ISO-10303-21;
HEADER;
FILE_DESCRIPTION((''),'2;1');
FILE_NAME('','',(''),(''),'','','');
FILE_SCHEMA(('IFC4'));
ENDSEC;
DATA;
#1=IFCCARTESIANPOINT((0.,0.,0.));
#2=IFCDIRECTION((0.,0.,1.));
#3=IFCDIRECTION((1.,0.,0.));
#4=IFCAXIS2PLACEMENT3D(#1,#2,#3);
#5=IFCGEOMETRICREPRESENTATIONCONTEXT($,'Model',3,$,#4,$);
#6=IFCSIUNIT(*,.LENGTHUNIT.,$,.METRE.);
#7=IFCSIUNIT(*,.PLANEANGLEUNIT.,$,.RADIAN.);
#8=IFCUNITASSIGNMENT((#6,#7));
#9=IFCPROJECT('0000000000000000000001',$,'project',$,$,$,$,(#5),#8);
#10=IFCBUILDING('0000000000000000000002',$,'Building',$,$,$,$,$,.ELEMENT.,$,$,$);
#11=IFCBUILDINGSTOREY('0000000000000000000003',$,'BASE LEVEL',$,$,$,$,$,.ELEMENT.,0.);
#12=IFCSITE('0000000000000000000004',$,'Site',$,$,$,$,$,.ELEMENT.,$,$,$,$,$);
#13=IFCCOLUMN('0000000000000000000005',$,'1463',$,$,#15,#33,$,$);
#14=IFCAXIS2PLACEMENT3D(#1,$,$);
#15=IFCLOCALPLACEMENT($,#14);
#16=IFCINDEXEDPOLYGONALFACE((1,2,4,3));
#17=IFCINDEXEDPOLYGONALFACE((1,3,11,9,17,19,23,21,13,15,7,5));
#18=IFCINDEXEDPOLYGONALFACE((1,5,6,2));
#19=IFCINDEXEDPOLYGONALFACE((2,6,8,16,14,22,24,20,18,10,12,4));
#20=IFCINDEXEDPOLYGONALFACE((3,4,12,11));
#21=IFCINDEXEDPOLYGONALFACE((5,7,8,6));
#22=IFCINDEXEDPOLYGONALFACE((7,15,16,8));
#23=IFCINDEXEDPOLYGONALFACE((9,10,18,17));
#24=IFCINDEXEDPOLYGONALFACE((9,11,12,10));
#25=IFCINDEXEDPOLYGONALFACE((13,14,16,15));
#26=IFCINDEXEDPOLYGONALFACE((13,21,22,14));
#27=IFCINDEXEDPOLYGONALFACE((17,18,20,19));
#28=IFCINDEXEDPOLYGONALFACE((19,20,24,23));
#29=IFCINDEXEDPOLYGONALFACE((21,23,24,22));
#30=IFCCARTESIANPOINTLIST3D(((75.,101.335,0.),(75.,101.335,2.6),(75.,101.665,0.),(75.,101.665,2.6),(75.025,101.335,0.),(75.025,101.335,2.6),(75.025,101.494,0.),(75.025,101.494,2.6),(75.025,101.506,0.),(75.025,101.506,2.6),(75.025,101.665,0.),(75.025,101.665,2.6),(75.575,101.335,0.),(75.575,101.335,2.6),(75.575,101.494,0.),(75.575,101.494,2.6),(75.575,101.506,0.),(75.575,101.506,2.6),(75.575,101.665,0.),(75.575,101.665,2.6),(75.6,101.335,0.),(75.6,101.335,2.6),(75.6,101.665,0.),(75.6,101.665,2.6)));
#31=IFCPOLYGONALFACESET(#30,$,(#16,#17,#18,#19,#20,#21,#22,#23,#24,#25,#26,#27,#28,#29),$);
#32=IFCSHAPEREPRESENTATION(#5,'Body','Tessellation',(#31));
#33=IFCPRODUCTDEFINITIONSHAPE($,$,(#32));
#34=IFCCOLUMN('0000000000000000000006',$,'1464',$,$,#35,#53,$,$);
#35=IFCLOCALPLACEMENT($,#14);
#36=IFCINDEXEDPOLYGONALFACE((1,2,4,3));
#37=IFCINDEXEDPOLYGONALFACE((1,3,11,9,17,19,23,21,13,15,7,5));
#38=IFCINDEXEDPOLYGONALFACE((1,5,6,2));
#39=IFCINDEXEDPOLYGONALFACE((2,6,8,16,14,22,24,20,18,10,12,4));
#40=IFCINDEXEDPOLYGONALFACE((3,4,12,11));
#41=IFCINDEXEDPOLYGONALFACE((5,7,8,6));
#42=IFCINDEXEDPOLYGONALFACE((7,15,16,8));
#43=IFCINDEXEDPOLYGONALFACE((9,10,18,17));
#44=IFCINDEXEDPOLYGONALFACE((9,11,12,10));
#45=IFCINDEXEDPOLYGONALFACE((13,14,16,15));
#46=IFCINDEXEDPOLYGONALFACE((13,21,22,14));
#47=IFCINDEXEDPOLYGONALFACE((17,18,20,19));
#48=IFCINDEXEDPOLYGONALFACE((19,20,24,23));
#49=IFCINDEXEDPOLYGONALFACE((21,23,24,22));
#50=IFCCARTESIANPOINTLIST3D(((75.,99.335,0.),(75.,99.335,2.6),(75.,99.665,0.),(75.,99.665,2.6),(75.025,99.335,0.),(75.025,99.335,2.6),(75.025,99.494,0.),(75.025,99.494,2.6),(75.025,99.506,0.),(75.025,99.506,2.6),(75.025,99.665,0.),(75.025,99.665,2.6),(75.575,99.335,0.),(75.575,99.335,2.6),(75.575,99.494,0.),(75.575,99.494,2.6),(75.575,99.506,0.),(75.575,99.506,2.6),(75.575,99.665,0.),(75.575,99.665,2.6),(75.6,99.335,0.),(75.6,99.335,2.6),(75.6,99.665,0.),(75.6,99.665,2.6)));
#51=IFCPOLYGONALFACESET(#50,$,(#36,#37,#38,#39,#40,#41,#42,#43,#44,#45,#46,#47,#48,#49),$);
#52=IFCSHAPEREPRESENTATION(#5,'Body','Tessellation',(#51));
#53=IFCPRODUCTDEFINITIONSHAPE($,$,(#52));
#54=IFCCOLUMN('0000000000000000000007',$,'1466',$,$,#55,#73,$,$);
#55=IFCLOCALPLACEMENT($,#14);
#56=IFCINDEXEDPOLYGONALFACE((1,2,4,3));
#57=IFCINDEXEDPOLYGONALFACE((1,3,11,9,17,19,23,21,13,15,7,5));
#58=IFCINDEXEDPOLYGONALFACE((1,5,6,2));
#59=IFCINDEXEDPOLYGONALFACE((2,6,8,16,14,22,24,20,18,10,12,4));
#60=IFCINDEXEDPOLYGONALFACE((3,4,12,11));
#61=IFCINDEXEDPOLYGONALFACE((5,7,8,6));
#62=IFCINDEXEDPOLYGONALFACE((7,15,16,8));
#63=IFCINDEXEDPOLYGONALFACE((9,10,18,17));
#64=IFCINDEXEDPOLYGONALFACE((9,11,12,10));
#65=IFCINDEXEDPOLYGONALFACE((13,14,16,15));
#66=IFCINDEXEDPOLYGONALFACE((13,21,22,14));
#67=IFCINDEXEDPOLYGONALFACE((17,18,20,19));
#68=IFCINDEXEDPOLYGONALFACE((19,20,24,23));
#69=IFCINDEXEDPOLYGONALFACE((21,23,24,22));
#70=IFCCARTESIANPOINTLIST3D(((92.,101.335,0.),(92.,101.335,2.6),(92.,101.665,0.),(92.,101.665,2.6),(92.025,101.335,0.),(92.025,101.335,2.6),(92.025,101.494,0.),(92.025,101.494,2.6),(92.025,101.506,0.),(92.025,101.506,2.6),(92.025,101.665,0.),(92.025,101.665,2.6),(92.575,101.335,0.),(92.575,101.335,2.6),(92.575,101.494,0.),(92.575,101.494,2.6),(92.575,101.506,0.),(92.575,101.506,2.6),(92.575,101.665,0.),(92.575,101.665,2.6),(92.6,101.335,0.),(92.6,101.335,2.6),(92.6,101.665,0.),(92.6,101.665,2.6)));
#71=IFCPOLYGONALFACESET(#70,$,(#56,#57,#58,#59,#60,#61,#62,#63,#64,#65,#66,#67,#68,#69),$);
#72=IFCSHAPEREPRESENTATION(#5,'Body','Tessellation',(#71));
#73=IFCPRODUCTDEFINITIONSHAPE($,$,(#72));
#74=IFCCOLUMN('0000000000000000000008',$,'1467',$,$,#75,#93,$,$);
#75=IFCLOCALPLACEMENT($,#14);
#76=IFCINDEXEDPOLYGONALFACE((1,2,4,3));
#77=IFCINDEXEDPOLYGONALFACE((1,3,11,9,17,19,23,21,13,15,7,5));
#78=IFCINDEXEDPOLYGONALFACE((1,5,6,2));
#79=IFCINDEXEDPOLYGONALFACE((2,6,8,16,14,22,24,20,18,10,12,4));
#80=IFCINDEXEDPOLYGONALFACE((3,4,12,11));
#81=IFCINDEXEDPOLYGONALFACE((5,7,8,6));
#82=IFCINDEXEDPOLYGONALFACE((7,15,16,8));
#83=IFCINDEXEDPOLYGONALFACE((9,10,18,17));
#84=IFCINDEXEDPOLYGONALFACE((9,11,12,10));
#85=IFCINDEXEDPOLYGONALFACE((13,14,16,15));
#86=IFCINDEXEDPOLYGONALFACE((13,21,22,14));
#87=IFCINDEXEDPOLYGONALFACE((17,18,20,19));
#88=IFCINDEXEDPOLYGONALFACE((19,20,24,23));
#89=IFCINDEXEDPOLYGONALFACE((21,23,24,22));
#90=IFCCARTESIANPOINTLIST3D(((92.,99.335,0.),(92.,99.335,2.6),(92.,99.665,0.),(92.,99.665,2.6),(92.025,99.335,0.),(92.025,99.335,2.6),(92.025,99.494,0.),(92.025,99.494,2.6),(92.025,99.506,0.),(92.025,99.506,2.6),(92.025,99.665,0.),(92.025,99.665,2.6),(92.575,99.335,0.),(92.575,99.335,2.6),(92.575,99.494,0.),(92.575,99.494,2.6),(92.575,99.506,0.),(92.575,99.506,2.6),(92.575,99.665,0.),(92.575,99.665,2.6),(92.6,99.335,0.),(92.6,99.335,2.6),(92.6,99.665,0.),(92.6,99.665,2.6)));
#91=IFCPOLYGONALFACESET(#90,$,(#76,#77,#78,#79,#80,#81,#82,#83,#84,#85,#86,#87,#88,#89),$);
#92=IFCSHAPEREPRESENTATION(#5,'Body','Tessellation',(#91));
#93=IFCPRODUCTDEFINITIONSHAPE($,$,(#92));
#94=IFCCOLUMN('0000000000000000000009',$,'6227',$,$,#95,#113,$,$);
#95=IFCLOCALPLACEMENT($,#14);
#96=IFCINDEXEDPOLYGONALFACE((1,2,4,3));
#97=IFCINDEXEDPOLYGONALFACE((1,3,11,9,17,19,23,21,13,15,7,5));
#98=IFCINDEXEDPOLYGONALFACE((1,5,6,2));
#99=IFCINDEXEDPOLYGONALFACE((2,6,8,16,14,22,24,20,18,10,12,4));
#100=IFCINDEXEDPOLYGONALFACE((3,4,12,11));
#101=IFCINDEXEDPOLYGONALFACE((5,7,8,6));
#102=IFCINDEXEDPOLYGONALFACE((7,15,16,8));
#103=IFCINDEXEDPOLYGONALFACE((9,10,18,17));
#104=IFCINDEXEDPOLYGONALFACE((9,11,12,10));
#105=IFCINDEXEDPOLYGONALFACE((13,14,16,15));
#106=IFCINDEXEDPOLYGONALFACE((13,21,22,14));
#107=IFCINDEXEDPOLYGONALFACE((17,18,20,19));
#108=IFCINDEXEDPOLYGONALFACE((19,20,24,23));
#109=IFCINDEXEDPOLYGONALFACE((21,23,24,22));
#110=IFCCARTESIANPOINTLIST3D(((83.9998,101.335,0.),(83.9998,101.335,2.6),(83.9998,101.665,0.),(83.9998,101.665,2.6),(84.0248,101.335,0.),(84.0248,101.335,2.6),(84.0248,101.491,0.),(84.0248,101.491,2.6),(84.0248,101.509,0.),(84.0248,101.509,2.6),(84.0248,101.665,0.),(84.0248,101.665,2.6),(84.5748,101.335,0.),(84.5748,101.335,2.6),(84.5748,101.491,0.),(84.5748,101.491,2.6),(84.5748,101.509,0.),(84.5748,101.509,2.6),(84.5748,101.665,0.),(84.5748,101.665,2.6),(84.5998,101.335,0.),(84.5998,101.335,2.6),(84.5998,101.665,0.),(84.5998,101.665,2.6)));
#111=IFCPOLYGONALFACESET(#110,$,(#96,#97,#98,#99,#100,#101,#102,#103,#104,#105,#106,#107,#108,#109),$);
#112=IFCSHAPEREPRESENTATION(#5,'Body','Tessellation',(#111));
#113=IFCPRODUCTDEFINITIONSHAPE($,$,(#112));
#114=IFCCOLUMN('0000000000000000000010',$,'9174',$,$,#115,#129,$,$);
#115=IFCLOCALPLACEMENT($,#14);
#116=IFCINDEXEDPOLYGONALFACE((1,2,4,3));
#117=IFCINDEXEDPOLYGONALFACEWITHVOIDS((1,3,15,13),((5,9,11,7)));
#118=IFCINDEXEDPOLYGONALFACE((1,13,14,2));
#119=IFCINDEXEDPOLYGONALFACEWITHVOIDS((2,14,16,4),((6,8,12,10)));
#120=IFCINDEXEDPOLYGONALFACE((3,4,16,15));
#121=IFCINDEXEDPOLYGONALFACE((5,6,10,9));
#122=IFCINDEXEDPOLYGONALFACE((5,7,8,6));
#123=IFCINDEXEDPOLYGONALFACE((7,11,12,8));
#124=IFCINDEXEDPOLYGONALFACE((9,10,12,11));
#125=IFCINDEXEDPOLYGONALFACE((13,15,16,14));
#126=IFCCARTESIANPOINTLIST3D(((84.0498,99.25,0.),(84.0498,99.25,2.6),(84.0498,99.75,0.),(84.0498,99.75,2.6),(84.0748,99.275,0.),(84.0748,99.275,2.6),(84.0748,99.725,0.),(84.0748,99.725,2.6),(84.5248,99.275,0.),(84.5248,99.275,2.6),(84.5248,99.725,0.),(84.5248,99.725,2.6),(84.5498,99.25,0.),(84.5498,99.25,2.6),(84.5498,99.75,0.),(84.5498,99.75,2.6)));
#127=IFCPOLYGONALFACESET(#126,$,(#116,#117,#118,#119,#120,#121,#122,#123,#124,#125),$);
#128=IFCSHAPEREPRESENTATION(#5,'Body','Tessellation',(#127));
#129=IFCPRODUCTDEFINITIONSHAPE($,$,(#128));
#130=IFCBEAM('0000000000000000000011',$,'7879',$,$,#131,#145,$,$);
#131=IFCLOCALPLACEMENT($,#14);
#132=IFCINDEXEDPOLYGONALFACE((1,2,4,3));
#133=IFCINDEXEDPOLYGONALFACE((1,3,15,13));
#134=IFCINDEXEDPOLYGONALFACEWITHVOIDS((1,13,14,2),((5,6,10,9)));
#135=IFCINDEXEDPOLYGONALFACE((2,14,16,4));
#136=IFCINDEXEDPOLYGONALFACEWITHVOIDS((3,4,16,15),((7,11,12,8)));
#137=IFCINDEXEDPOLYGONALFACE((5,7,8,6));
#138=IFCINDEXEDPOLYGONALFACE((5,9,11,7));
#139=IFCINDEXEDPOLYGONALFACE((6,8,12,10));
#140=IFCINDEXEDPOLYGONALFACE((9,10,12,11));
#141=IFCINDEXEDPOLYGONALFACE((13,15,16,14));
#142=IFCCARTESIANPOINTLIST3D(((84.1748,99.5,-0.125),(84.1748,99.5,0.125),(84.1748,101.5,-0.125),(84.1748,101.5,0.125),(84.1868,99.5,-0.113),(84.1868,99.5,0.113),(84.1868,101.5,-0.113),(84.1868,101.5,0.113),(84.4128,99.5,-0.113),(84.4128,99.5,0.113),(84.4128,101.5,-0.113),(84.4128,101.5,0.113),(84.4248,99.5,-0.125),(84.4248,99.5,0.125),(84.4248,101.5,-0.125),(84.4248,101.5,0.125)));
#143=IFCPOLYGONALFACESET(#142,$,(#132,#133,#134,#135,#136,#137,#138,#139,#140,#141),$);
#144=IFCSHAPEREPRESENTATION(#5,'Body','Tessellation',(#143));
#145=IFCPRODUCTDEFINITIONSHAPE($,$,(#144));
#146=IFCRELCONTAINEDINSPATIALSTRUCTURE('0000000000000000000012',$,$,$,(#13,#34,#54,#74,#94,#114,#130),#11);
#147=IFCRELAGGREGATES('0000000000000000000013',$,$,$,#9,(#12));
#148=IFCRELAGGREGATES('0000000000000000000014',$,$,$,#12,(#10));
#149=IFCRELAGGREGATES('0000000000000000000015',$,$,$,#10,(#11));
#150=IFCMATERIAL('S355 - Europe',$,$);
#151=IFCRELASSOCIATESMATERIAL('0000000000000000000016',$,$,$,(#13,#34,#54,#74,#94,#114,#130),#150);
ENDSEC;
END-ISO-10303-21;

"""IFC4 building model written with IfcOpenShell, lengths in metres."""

from ifc_helpers import new_model, si_unit, frame, origin_with_axes, origin_2d_with_axis, place, context, project, spatial, hollow_rectangle, i_section, extrude, material, material_profile, profile_set, profile_usage, element, save


model = new_model("IFC4")

# Units and contexts
model_context = context("Model", 3, world=origin_with_axes())
ifc_project = project(units=[si_unit("LENGTHUNIT", "METRE"), si_unit("PLANEANGLEUNIT", "RADIAN")], contexts=[model_context])

# Site, building, storey
site = spatial("IfcSite", under=ifc_project, Name="Site", CompositionType="ELEMENT")
building = spatial("IfcBuilding", under=site, Name="Building", CompositionType="ELEMENT")
storey = spatial("IfcBuildingStorey", under=building, Name="BASE LEVEL", CompositionType="ELEMENT", Elevation=0.0)

# Columns
ifc_material = material(Name="S355 - Europe")
ifc_material_profile_1 = material_profile(ifc_material, i_section(OverallWidth=0.33, OverallDepth=0.6, WebThickness=0.012, FlangeThickness=0.025, at=origin_2d_with_axis()))
ifc_profile_set_1 = profile_set([ifc_material_profile_1])
ifc_profile_usage_1 = profile_usage(ifc_profile_set_1, cardinal=10)
column_1_placement = place(None, frame((75.3, 101.5, 0.0), z_axis=(0.0, 0.0, 1.0), x_axis=(0.0, -1.0, 0.0)))
element("IfcColumn", 1, at=column_1_placement, inside=storey, material=ifc_profile_usage_1, Name="1463", context=model_context, shape_type="SweptSolid", body=[
    extrude(i_section(OverallWidth=0.33, OverallDepth=0.6, WebThickness=0.012, FlangeThickness=0.025, at=origin_2d_with_axis()), origin_with_axes(), (0.0, 0.0, 1.0), 2.6),
])
ifc_material_profile_2 = material_profile(ifc_material, i_section(OverallWidth=0.33, OverallDepth=0.6, WebThickness=0.012, FlangeThickness=0.025, at=origin_2d_with_axis()))
ifc_profile_set_2 = profile_set([ifc_material_profile_2])
ifc_profile_usage_2 = profile_usage(ifc_profile_set_2, cardinal=10)
column_2_placement = place(None, frame((75.3, 99.5, 0.0), z_axis=(0.0, 0.0, 1.0), x_axis=(0.0, -1.0, 0.0)))
element("IfcColumn", 2, at=column_2_placement, inside=storey, material=ifc_profile_usage_2, Name="1464", context=model_context, shape_type="SweptSolid", body=[
    extrude(i_section(OverallWidth=0.33, OverallDepth=0.6, WebThickness=0.012, FlangeThickness=0.025, at=origin_2d_with_axis()), origin_with_axes(), (0.0, 0.0, 1.0), 2.6),
])
ifc_material_profile_3 = material_profile(ifc_material, i_section(OverallWidth=0.33, OverallDepth=0.6, WebThickness=0.012, FlangeThickness=0.025, at=origin_2d_with_axis()))
ifc_profile_set_3 = profile_set([ifc_material_profile_3])
ifc_profile_usage_3 = profile_usage(ifc_profile_set_3, cardinal=10)
column_3_placement = place(None, frame((92.3, 101.5, 0.0), z_axis=(0.0, 0.0, 1.0), x_axis=(0.0, -1.0, 0.0)))
element("IfcColumn", 3, at=column_3_placement, inside=storey, material=ifc_profile_usage_3, Name="1466", context=model_context, shape_type="SweptSolid", body=[
    extrude(i_section(OverallWidth=0.33, OverallDepth=0.6, WebThickness=0.012, FlangeThickness=0.025, at=origin_2d_with_axis()), origin_with_axes(), (0.0, 0.0, 1.0), 2.6),
])
ifc_material_profile_4 = material_profile(ifc_material, i_section(OverallWidth=0.33, OverallDepth=0.6, WebThickness=0.012, FlangeThickness=0.025, at=origin_2d_with_axis()))
ifc_profile_set_4 = profile_set([ifc_material_profile_4])
ifc_profile_usage_4 = profile_usage(ifc_profile_set_4, cardinal=10)
column_4_placement = place(None, frame((92.3, 99.5, 0.0), z_axis=(0.0, 0.0, 1.0), x_axis=(0.0, -1.0, 0.0)))
element("IfcColumn", 4, at=column_4_placement, inside=storey, material=ifc_profile_usage_4, Name="1467", context=model_context, shape_type="SweptSolid", body=[
    extrude(i_section(OverallWidth=0.33, OverallDepth=0.6, WebThickness=0.012, FlangeThickness=0.025, at=origin_2d_with_axis()), origin_with_axes(), (0.0, 0.0, 1.0), 2.6),
])
ifc_material_profile_5 = material_profile(ifc_material, i_section(OverallWidth=0.33, OverallDepth=0.6, WebThickness=0.018, FlangeThickness=0.025, at=origin_2d_with_axis()))
ifc_profile_set_5 = profile_set([ifc_material_profile_5])
ifc_profile_usage_5 = profile_usage(ifc_profile_set_5, cardinal=10)
column_5_placement = place(None, frame((84.2998, 101.5, 0.0), z_axis=(0.0, 0.0, 1.0), x_axis=(0.0, -1.0, 0.0)))
element("IfcColumn", 5, at=column_5_placement, inside=storey, material=ifc_profile_usage_5, Name="6227", context=model_context, shape_type="SweptSolid", body=[
    extrude(i_section(OverallWidth=0.33, OverallDepth=0.6, WebThickness=0.018, FlangeThickness=0.025, at=origin_2d_with_axis()), origin_with_axes(), (0.0, 0.0, 1.0), 2.6),
])
ifc_material_profile_6 = material_profile(ifc_material, hollow_rectangle(XDim=0.5, YDim=0.5, WallThickness=0.025, at=origin_2d_with_axis()))
ifc_profile_set_6 = profile_set([ifc_material_profile_6])
ifc_profile_usage_6 = profile_usage(ifc_profile_set_6, cardinal=10)
column_6_placement = place(None, frame((84.2998, 99.5, 0.0), z_axis=(0.0, 0.0, 1.0), x_axis=(0.0, -1.0, 0.0)))
element("IfcColumn", 6, at=column_6_placement, inside=storey, material=ifc_profile_usage_6, Name="9174", context=model_context, shape_type="SweptSolid", body=[
    extrude(hollow_rectangle(XDim=0.5, YDim=0.5, WallThickness=0.025, at=origin_2d_with_axis()), origin_with_axes(), (0.0, 0.0, 1.0), 2.6),
])

# Beam
ifc_material_profile_7 = material_profile(ifc_material, hollow_rectangle(XDim=0.25, YDim=0.25, WallThickness=0.012, at=origin_2d_with_axis()))
ifc_profile_set_7 = profile_set([ifc_material_profile_7])
ifc_profile_usage_7 = profile_usage(ifc_profile_set_7, cardinal=10)
beam_1_placement = place(None, frame((84.2998, 101.5, 0.0), z_axis=(0.0, -1.0, 0.0), x_axis=(1.0, 0.0, 0.0)))
element("IfcBeam", 7, at=beam_1_placement, inside=storey, material=ifc_profile_usage_7, Name="7879", context=model_context, shape_type="SweptSolid", body=[
    extrude(hollow_rectangle(XDim=0.25, YDim=0.25, WallThickness=0.012, at=origin_2d_with_axis()), origin_with_axes(), (0.0, 0.0, 1.0), 2.0),
])

save(model, "model.ifc")
